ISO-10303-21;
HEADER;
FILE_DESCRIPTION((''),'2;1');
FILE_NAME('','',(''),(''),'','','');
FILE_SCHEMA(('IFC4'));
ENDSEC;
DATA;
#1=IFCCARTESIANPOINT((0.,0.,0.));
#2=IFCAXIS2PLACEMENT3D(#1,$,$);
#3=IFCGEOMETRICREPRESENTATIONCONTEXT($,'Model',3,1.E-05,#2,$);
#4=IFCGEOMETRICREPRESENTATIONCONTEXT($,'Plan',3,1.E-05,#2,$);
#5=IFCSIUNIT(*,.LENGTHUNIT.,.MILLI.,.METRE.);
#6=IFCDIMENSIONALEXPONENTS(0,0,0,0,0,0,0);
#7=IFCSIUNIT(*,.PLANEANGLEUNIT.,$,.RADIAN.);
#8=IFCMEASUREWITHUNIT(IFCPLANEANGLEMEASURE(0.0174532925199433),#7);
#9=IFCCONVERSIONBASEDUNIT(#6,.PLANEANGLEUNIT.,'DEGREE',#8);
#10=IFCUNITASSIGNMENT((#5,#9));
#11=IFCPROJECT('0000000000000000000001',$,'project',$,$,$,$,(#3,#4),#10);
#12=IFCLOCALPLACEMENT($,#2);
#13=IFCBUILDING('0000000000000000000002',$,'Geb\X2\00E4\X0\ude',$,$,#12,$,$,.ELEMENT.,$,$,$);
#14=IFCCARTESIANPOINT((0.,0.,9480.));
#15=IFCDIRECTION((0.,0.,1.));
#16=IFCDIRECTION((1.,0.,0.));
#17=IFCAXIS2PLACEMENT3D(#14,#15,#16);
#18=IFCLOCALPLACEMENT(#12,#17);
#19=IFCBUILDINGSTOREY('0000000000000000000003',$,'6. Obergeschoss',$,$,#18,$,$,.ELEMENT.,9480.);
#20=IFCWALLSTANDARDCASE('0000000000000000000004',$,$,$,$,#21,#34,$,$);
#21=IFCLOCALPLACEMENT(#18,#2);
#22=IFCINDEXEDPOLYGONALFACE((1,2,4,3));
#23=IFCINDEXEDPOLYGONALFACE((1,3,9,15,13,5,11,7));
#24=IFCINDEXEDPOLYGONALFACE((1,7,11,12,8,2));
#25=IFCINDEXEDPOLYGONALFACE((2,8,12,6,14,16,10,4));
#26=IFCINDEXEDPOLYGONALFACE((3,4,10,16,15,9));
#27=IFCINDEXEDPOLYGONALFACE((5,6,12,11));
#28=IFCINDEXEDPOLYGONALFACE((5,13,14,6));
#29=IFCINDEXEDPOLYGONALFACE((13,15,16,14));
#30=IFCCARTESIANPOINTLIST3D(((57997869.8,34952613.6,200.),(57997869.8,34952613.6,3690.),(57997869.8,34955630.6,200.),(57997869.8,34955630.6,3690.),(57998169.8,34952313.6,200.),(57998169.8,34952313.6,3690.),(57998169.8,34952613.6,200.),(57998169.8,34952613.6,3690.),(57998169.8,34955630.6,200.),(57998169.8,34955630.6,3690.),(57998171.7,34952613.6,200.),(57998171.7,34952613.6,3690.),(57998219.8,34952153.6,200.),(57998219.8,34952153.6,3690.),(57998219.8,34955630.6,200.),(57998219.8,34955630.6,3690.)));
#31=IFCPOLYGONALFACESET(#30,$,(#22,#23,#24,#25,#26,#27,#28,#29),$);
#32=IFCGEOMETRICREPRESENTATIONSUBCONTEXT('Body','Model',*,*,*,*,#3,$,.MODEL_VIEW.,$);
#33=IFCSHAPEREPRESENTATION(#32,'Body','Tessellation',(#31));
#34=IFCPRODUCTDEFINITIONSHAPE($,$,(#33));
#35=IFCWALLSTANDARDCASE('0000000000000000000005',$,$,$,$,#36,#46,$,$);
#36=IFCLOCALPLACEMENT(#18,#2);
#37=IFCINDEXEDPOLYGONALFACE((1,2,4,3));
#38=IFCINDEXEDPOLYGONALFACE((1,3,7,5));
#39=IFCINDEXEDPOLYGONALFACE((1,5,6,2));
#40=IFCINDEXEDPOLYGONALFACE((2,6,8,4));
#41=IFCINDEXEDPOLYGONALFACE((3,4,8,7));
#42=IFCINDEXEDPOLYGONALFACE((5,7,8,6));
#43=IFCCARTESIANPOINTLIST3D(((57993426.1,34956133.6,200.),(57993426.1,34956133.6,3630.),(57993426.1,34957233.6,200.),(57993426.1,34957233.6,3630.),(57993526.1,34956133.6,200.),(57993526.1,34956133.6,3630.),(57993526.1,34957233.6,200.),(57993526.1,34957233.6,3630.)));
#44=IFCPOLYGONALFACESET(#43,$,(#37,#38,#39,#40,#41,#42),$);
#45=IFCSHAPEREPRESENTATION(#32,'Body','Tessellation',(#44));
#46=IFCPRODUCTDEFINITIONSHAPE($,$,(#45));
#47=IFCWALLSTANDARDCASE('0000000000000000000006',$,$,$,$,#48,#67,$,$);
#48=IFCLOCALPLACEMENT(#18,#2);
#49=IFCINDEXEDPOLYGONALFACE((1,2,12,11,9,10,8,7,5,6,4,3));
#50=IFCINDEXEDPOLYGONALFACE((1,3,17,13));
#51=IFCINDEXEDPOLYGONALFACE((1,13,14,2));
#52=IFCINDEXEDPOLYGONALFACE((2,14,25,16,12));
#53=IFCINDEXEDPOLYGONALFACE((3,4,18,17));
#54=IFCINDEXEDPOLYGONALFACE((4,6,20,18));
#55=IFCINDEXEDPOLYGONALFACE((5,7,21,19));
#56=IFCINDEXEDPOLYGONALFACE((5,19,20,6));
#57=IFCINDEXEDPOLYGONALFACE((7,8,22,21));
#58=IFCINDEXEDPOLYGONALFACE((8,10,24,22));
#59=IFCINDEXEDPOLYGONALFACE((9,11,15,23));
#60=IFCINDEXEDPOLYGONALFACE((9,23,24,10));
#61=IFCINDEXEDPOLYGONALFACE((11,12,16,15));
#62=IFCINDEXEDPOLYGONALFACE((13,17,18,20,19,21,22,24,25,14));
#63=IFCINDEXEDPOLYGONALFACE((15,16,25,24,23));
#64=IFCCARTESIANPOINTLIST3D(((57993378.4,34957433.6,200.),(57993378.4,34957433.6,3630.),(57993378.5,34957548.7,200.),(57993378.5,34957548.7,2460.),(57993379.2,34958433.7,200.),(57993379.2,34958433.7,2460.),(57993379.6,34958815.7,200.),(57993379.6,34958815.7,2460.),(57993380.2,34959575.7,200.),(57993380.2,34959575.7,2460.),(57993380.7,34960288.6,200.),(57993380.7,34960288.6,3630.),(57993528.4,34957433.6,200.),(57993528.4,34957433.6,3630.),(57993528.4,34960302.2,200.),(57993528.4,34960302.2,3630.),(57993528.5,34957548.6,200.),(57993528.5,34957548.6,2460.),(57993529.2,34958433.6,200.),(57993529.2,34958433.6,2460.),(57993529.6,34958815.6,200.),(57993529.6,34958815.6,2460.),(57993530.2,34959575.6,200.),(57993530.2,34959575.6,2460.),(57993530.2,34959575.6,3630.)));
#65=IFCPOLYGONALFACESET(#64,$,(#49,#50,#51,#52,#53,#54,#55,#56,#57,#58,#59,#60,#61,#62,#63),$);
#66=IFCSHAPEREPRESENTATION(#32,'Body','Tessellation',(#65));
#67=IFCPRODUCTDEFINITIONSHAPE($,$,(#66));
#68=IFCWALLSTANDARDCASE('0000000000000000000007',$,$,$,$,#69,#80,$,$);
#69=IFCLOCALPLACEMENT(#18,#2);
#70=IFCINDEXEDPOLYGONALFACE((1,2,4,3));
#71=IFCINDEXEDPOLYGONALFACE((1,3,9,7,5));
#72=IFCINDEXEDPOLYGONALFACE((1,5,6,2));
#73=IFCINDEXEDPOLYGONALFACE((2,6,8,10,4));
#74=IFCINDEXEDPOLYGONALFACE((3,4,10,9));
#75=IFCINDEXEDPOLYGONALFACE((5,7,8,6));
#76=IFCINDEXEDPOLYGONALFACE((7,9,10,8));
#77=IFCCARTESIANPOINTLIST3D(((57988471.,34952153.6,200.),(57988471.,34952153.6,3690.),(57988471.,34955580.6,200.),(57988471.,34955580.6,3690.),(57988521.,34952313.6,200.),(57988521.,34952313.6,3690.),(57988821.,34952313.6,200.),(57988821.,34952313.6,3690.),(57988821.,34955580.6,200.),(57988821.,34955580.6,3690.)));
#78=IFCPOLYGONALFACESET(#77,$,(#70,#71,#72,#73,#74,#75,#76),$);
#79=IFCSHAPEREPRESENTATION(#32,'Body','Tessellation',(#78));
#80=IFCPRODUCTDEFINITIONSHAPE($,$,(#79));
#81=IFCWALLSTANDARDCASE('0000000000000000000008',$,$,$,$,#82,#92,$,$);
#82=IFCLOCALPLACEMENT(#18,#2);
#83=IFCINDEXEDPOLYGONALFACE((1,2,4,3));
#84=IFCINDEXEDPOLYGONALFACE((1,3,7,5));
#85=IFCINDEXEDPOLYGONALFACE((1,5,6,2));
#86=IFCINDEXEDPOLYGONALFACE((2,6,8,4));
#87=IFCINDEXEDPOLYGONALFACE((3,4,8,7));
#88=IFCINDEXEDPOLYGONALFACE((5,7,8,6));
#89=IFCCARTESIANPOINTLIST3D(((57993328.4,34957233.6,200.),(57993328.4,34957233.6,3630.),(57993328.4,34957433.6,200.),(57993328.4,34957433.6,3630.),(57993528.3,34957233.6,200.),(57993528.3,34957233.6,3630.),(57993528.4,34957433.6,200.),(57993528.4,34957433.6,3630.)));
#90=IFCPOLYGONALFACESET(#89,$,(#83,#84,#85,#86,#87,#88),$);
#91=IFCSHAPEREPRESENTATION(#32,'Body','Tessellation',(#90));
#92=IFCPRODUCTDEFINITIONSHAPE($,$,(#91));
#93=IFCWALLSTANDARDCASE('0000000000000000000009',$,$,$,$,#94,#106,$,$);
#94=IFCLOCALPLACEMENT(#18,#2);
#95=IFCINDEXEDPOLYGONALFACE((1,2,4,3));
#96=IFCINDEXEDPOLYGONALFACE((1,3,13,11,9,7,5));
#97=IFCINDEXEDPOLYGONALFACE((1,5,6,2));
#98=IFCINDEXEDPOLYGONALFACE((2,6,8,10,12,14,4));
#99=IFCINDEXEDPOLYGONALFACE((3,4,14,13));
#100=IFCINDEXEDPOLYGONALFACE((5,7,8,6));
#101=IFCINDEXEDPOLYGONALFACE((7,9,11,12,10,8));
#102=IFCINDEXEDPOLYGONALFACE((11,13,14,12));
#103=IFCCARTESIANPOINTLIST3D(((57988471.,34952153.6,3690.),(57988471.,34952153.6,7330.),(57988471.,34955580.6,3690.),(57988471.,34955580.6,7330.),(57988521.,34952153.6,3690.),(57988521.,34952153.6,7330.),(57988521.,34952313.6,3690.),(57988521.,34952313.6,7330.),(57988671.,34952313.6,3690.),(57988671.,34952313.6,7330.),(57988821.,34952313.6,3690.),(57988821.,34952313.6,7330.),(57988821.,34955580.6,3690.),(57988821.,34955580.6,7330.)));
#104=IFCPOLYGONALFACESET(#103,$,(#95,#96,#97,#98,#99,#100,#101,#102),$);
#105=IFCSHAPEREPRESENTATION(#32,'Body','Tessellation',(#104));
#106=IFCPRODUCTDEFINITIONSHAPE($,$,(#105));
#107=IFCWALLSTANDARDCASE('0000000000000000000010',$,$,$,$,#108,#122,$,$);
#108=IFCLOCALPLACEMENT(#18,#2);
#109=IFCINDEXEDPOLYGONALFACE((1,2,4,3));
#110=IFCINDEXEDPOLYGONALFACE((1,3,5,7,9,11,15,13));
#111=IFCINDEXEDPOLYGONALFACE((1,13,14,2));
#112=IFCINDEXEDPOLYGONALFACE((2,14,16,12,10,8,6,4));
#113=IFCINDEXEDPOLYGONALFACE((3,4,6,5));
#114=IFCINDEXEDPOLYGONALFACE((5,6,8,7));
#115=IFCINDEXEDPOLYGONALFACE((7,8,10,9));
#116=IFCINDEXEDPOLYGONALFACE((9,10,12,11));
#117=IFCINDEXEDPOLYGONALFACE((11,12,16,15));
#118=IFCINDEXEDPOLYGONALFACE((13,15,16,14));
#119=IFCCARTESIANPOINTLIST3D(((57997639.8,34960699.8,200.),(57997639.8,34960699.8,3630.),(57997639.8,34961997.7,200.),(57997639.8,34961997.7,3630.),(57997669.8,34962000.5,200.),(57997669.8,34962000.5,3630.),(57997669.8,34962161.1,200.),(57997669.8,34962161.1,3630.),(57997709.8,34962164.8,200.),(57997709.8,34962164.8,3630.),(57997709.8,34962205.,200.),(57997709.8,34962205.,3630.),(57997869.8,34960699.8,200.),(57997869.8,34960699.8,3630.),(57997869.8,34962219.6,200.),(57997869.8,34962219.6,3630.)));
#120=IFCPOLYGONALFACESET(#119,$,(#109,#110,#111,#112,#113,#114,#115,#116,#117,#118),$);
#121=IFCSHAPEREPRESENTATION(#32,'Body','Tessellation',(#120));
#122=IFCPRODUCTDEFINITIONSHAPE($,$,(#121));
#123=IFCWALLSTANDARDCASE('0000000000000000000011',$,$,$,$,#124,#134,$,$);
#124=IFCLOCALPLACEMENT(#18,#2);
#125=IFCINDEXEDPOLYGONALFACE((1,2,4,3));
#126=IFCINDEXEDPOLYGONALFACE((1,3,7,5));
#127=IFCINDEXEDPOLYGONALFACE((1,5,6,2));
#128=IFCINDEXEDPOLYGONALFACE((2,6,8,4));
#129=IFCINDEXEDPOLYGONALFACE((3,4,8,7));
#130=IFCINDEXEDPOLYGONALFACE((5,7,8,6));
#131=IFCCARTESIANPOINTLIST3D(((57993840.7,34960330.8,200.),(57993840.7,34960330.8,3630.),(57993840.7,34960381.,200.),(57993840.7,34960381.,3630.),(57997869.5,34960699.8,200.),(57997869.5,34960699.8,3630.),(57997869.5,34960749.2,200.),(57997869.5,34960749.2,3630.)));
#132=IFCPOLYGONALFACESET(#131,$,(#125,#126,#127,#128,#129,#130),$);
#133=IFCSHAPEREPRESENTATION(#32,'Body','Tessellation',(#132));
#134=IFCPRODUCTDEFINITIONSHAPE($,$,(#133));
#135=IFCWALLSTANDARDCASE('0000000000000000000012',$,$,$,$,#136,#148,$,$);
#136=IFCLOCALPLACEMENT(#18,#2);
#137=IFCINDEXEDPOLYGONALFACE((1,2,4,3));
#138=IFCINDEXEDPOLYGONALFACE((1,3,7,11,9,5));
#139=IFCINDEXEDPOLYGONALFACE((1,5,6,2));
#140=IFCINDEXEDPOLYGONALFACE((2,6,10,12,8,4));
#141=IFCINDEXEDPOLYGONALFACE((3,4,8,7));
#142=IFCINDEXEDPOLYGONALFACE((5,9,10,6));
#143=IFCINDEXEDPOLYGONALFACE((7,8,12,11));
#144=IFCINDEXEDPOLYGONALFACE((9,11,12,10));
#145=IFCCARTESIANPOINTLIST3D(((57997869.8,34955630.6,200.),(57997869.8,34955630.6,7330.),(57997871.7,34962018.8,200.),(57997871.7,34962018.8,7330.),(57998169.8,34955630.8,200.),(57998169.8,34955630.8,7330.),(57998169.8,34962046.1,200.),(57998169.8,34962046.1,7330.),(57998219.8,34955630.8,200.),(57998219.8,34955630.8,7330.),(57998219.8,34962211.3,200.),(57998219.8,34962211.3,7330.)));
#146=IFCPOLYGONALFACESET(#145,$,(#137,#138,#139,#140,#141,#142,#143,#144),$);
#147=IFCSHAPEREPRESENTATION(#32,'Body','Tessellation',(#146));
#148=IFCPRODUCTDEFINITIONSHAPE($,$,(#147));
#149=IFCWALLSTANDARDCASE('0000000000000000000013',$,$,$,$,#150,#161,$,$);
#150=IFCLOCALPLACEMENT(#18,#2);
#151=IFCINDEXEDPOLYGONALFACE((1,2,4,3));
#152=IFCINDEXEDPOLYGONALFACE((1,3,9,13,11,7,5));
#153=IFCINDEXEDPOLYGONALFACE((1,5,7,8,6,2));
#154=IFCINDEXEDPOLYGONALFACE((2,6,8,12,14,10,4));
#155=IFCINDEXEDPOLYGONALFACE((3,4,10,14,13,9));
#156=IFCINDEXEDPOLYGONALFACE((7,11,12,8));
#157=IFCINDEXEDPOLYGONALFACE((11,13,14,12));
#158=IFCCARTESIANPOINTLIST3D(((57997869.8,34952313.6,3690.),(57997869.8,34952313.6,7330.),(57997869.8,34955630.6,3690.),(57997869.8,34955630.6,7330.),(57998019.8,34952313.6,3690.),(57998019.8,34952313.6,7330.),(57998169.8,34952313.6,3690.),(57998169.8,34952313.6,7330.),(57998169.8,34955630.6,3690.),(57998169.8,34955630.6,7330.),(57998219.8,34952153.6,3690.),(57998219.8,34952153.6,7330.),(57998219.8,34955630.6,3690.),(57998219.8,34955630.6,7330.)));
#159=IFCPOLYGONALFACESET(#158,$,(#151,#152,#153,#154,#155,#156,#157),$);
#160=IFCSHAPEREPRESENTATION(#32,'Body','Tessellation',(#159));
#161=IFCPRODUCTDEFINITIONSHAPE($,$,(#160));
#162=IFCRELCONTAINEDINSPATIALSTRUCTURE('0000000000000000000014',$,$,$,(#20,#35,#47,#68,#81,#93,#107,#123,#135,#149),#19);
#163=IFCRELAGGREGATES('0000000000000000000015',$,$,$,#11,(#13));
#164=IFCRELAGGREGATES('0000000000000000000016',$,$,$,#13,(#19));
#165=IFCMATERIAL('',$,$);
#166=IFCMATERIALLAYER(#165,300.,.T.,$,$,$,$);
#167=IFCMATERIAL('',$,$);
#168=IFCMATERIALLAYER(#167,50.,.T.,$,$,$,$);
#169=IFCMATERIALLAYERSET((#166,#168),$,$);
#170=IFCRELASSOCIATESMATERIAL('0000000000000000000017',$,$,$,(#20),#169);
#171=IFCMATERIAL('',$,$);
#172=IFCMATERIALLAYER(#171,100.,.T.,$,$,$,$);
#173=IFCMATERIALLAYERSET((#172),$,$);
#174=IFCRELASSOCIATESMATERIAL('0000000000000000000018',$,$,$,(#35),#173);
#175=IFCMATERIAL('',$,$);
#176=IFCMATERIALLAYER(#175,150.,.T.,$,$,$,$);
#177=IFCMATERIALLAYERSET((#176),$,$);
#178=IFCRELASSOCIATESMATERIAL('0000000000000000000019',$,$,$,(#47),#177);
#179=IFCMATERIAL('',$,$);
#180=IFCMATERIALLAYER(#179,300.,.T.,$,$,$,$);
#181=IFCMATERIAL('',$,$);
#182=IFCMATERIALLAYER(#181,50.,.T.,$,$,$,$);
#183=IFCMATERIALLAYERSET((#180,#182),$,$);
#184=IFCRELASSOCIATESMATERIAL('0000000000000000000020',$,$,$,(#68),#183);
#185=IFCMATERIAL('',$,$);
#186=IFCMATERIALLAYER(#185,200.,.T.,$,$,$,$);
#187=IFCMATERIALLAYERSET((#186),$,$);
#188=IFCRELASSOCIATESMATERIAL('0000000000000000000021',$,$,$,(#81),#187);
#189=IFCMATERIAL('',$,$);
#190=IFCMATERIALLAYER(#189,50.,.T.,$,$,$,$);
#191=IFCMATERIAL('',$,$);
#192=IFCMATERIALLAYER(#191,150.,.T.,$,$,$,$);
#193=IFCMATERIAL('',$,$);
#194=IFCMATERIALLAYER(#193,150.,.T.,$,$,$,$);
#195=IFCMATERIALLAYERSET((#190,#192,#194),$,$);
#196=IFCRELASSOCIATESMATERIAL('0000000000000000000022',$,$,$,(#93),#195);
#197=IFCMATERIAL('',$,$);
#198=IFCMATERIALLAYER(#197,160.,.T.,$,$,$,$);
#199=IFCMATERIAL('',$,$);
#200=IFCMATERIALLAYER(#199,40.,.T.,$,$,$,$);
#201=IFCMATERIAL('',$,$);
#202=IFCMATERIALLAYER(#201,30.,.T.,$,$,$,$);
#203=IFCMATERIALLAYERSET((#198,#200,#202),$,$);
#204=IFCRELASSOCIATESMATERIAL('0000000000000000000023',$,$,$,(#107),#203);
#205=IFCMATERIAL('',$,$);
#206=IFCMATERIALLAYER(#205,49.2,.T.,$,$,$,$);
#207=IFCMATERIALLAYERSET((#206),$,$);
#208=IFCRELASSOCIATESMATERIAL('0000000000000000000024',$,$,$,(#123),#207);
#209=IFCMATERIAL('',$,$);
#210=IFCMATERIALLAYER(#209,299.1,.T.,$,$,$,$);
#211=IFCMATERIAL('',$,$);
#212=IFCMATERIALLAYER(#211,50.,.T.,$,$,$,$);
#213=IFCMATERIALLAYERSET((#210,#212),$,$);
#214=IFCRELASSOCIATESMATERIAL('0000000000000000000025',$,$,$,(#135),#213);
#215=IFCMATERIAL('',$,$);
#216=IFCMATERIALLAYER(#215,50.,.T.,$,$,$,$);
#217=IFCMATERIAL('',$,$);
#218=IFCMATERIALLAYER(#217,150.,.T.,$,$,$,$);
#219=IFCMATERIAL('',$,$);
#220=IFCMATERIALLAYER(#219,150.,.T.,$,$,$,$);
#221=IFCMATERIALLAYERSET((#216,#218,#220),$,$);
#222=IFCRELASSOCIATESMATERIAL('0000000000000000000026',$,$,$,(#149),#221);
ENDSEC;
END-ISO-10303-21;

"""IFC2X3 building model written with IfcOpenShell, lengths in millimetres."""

from ifc_helpers import new_model, entity, si_unit, converted_unit, frame, frame_2d, origin, origin_with_axes, place, context, subcontext, project, spatial, polyline, rectangle, outline, extrude, material, layer, layer_set, layer_usage, element, save


model = new_model("IFC2X3")

# Units and contexts
model_context = context("Model", 3, precision=1e-05, world=origin())
plan_context = context("Plan", 3, precision=1e-05, world=origin())
body_context = subcontext(model_context, "Body", "Model", "MODEL_VIEW")
ifc_project = project(units=[si_unit("LENGTHUNIT", "METRE", prefix="MILLI"), converted_unit("PLANEANGLEUNIT", "DEGREE", entity("IfcPlaneAngleMeasure", 0.0174532925199433), si_unit("PLANEANGLEUNIT", "RADIAN"), dimensions=[0, 0, 0, 0, 0, 0, 0])], contexts=[model_context, plan_context])

# Building, storey
building_placement = place(None, origin())
building = spatial("IfcBuilding", under=ifc_project, at=building_placement, Name="Gebäude", CompositionType="ELEMENT")
storey_placement = place(building_placement, frame((0.0, 0.0, 9480.0), z_axis=(0.0, 0.0, 1.0), x_axis=(1.0, 0.0, 0.0)))
storey = spatial("IfcBuildingStorey", under=building, at=storey_placement, Name="6. Obergeschoss", CompositionType="ELEMENT", Elevation=9480.0)

# Walls
ifc_material_1 = material(Name="")
ifc_layer_1 = layer(ifc_material_1, 300.0, ventilated=True)
ifc_material_2 = material(Name="")
ifc_layer_2 = layer(ifc_material_2, 50.0, ventilated=True)
ifc_layer_set_1 = layer_set([ifc_layer_1, ifc_layer_2])
ifc_layer_usage_1 = layer_usage(ifc_layer_set_1, "AXIS2", "POSITIVE", 0.0)
wall_1_placement = place(storey_placement, frame((57997869.8, 34955630.6, 200.0), z_axis=(0.0, 0.0, 1.0), x_axis=(0.0, -1.0, 0.0)))
element("IfcWallStandardCase", 1, at=wall_1_placement, inside=storey, material=ifc_layer_usage_1, context=body_context, shape_type="SweptSolid", body=[
    extrude(outline(polyline([(0.0, 0.0), (3016.9, 0.0), (3016.9, 300.0), (3016.9, 301.9), (3316.9, 300.0), (3476.9, 350.0), (0.0, 350.0), (0.0, 300.0), (0.0, 0.0)])), origin_with_axes(), (0.0, 0.0, 1.0), 3490.0),
])
ifc_material_3 = material(Name="")
ifc_layer_3 = layer(ifc_material_3, 100.0, ventilated=True)
ifc_layer_set_2 = layer_set([ifc_layer_3])
ifc_layer_usage_2 = layer_usage(ifc_layer_set_2, "AXIS2", "POSITIVE", 0.0)
wall_2_placement = place(storey_placement, frame((57993426.1, 34957233.6, 200.0), z_axis=(0.0, 0.0, 1.0), x_axis=(0.0, -1.0, 0.0)))
element("IfcWallStandardCase", 2, at=wall_2_placement, inside=storey, material=ifc_layer_usage_2, context=body_context, shape_type="SweptSolid", body=[
    extrude(rectangle(XDim=1100.0, YDim=100.0, at=frame_2d((550.0, 50.0), x_axis=(1.0, 0.0))), origin_with_axes(), (0.0, 0.0, 1.0), 3430.0),
])

# Wall, openings
ifc_material_4 = material(Name="")
ifc_layer_4 = layer(ifc_material_4, 150.0, ventilated=True)
ifc_layer_set_3 = layer_set([ifc_layer_4])
ifc_layer_usage_3 = layer_usage(ifc_layer_set_3, "AXIS2", "POSITIVE", 0.0)
wall_3_placement = place(storey_placement, frame((57993380.7, 34960288.6, 200.0), z_axis=(0.0, 0.0, 1.0), x_axis=(-0.000802, -1.0, 0.0)))
wall_3 = element("IfcWallStandardCase", 3, at=wall_3_placement, inside=storey, material=ifc_layer_usage_3, context=body_context, shape_type="SweptSolid", body=[
    extrude(outline(polyline([(0.0, 0.0), (2855.1, 0.0), (2854.9, 150.0), (712.9, 150.0), (-13.6, 147.7), (0.0, 0.0)])), origin_with_axes(), (0.0, 0.0, 1.0), 3430.0),
])
opening_1_placement = place(wall_3_placement, frame((1854.9, 0.0, 0.0), z_axis=(0.0, 1.0, 0.0), x_axis=(0.0, 0.0, 1.0)))
element("IfcOpeningElement", 4, at=opening_1_placement, cuts=wall_3, ObjectType="Opening", context=body_context, shape_type="SweptSolid", body=[
    extrude(rectangle(XDim=2260.0, YDim=885.0, at=frame_2d((1130.0, 442.5), x_axis=(1.0, 0.0))), origin_with_axes(), (0.0, 0.0, 1.0), 150.0),
])
opening_2_placement = place(wall_3_placement, frame((712.9, 0.0, 0.0), z_axis=(0.0, 1.0, 0.0), x_axis=(0.0, 0.0, 1.0)))
element("IfcOpeningElement", 5, at=opening_2_placement, cuts=wall_3, ObjectType="Opening", context=body_context, shape_type="SweptSolid", body=[
    extrude(rectangle(XDim=2260.0, YDim=760.0, at=frame_2d((1130.0, 380.0), x_axis=(1.0, 0.0))), origin_with_axes(), (0.0, 0.0, 1.0), 150.0),
])

# Walls
ifc_material_5 = material(Name="")
ifc_layer_5 = layer(ifc_material_5, 300.0, ventilated=True)
ifc_material_6 = material(Name="")
ifc_layer_6 = layer(ifc_material_6, 50.0, ventilated=True)
ifc_layer_set_4 = layer_set([ifc_layer_5, ifc_layer_6])
ifc_layer_usage_4 = layer_usage(ifc_layer_set_4, "AXIS2", "POSITIVE", 0.0)
wall_4_placement = place(storey_placement, frame((57988821.0, 34952313.6, 200.0), z_axis=(0.0, 0.0, 1.0), x_axis=(0.0, 1.0, 0.0)))
element("IfcWallStandardCase", 6, at=wall_4_placement, inside=storey, material=ifc_layer_usage_4, context=body_context, shape_type="SweptSolid", body=[
    extrude(outline(polyline([(0.0, 0.0), (3266.9, 0.0), (3266.9, 350.0), (-160.0, 350.0), (0.0, 300.0), (0.0, 0.0)])), origin_with_axes(), (0.0, 0.0, 1.0), 3490.0),
])
ifc_material_7 = material(Name="")
ifc_layer_7 = layer(ifc_material_7, 200.0, ventilated=True)
ifc_layer_set_5 = layer_set([ifc_layer_7])
ifc_layer_usage_5 = layer_usage(ifc_layer_set_5, "AXIS2", "POSITIVE", 0.0)
wall_5_placement = place(storey_placement, frame((57993528.4, 34957433.6, 200.0), z_axis=(0.0, 0.0, 1.0), x_axis=(-1.0, 0.0, 0.0)))
element("IfcWallStandardCase", 7, at=wall_5_placement, inside=storey, material=ifc_layer_usage_5, context=body_context, shape_type="SweptSolid", body=[
    extrude(outline(polyline([(0.0, 0.0), (200.0, 0.0), (200.0, 200.0), (0.2, 200.0), (0.0, 0.0)])), origin_with_axes(), (0.0, 0.0, 1.0), 3430.0),
])
ifc_material_8 = material(Name="")
ifc_layer_8 = layer(ifc_material_8, 50.0, ventilated=True)
ifc_material_9 = material(Name="")
ifc_layer_9 = layer(ifc_material_9, 150.0, ventilated=True)
ifc_material_10 = material(Name="")
ifc_layer_10 = layer(ifc_material_10, 150.0, ventilated=True)
ifc_layer_set_6 = layer_set([ifc_layer_8, ifc_layer_9, ifc_layer_10])
ifc_layer_usage_6 = layer_usage(ifc_layer_set_6, "AXIS2", "POSITIVE", 0.0)
wall_6_placement = place(storey_placement, frame((57988821.0, 34952313.6, 3690.0), z_axis=(0.0, 0.0, 1.0), x_axis=(0.0, 1.0, 0.0)))
element("IfcWallStandardCase", 8, at=wall_6_placement, inside=storey, material=ifc_layer_usage_6, context=body_context, shape_type="SweptSolid", body=[
    extrude(outline(polyline([(-160.0, 350.0), (-160.0, 300.0), (0.0, 300.0), (0.0, 150.0), (0.0, 0.0), (3266.9, 0.0), (3266.9, 350.0), (-160.0, 350.0)])), origin_with_axes(), (0.0, 0.0, 1.0), 3640.0),
])
ifc_material_11 = material(Name="")
ifc_layer_11 = layer(ifc_material_11, 160.0, ventilated=True)
ifc_material_12 = material(Name="")
ifc_layer_12 = layer(ifc_material_12, 40.0, ventilated=True)
ifc_material_13 = material(Name="")
ifc_layer_13 = layer(ifc_material_13, 30.0, ventilated=True)
ifc_layer_set_7 = layer_set([ifc_layer_11, ifc_layer_12, ifc_layer_13])
ifc_layer_usage_7 = layer_usage(ifc_layer_set_7, "AXIS2", "POSITIVE", 0.0)
wall_7_placement = place(storey_placement, frame((57997869.8, 34960699.8, 200.0), z_axis=(0.0, 0.0, 1.0), x_axis=(0.0, 1.0, 0.0)))
element("IfcWallStandardCase", 9, at=wall_7_placement, inside=storey, material=ifc_layer_usage_7, context=body_context, shape_type="SweptSolid", body=[
    extrude(outline(polyline([(0.0, 0.0), (1519.9, 0.0), (1505.2, 160.0), (1465.0, 160.0), (1461.4, 200.0), (1300.7, 200.0), (1297.9, 230.0), (0.0, 230.0), (0.0, 0.0)])), origin_with_axes(), (0.0, 0.0, 1.0), 3430.0),
])
ifc_material_14 = material(Name="")
ifc_layer_14 = layer(ifc_material_14, 49.2, ventilated=True)
ifc_layer_set_8 = layer_set([ifc_layer_14])
ifc_layer_usage_8 = layer_usage(ifc_layer_set_8, "AXIS2", "POSITIVE", 0.0)
wall_8_placement = place(storey_placement, frame((57993840.7, 34960330.8, 200.0), z_axis=(0.0, 0.0, 1.0), x_axis=(0.995832, 0.091206, 0.0)))
element("IfcWallStandardCase", 10, at=wall_8_placement, inside=storey, material=ifc_layer_usage_8, context=body_context, shape_type="SweptSolid", body=[
    extrude(outline(polyline([(0.0, 0.0), (4045.7, 0.0), (4050.2, 49.2), (4.6, 50.0), (0.0, 0.0)])), origin_with_axes(), (0.0, 0.0, 1.0), 3430.0),
])
ifc_material_15 = material(Name="")
ifc_layer_15 = layer(ifc_material_15, 299.1, ventilated=True)
ifc_material_16 = material(Name="")
ifc_layer_16 = layer(ifc_material_16, 50.0, ventilated=True)
ifc_layer_set_9 = layer_set([ifc_layer_15, ifc_layer_16])
ifc_layer_usage_9 = layer_usage(ifc_layer_set_9, "AXIS2", "POSITIVE", 0.0)
wall_9_placement = place(storey_placement, frame((57997871.7, 34962018.8, 200.0), z_axis=(0.0, 0.0, 1.0), x_axis=(-0.000292, -1.0, 0.0)))
element("IfcWallStandardCase", 11, at=wall_9_placement, inside=storey, material=ifc_layer_usage_9, context=body_context, shape_type="SweptSolid", body=[
    extrude(outline(polyline([(0.0, 0.0), (6388.2, 0.0), (6387.9, 300.0), (6387.8, 350.0), (-192.7, 348.1), (-27.4, 298.1), (0.0, 0.0)])), origin_with_axes(), (0.0, 0.0, 1.0), 7130.0),
])
ifc_material_17 = material(Name="")
ifc_layer_17 = layer(ifc_material_17, 50.0, ventilated=True)
ifc_material_18 = material(Name="")
ifc_layer_18 = layer(ifc_material_18, 150.0, ventilated=True)
ifc_material_19 = material(Name="")
ifc_layer_19 = layer(ifc_material_19, 150.0, ventilated=True)
ifc_layer_set_10 = layer_set([ifc_layer_17, ifc_layer_18, ifc_layer_19])
ifc_layer_usage_10 = layer_usage(ifc_layer_set_10, "AXIS2", "POSITIVE", 0.0)
wall_10_placement = place(storey_placement, frame((57997869.8, 34955630.6, 3690.0), z_axis=(0.0, 0.0, 1.0), x_axis=(0.0, -1.0, 0.0)))
element("IfcWallStandardCase", 12, at=wall_10_placement, inside=storey, material=ifc_layer_usage_10, context=body_context, shape_type="SweptSolid", body=[
    extrude(outline(polyline([(0.0, 0.0), (3316.9, 0.0), (3316.9, 150.0), (3316.9, 300.0), (3476.9, 350.0), (0.0, 350.0), (0.0, 300.0), (0.0, 0.0)])), origin_with_axes(), (0.0, 0.0, 1.0), 3640.0),
])

save(model, "model.ifc")
